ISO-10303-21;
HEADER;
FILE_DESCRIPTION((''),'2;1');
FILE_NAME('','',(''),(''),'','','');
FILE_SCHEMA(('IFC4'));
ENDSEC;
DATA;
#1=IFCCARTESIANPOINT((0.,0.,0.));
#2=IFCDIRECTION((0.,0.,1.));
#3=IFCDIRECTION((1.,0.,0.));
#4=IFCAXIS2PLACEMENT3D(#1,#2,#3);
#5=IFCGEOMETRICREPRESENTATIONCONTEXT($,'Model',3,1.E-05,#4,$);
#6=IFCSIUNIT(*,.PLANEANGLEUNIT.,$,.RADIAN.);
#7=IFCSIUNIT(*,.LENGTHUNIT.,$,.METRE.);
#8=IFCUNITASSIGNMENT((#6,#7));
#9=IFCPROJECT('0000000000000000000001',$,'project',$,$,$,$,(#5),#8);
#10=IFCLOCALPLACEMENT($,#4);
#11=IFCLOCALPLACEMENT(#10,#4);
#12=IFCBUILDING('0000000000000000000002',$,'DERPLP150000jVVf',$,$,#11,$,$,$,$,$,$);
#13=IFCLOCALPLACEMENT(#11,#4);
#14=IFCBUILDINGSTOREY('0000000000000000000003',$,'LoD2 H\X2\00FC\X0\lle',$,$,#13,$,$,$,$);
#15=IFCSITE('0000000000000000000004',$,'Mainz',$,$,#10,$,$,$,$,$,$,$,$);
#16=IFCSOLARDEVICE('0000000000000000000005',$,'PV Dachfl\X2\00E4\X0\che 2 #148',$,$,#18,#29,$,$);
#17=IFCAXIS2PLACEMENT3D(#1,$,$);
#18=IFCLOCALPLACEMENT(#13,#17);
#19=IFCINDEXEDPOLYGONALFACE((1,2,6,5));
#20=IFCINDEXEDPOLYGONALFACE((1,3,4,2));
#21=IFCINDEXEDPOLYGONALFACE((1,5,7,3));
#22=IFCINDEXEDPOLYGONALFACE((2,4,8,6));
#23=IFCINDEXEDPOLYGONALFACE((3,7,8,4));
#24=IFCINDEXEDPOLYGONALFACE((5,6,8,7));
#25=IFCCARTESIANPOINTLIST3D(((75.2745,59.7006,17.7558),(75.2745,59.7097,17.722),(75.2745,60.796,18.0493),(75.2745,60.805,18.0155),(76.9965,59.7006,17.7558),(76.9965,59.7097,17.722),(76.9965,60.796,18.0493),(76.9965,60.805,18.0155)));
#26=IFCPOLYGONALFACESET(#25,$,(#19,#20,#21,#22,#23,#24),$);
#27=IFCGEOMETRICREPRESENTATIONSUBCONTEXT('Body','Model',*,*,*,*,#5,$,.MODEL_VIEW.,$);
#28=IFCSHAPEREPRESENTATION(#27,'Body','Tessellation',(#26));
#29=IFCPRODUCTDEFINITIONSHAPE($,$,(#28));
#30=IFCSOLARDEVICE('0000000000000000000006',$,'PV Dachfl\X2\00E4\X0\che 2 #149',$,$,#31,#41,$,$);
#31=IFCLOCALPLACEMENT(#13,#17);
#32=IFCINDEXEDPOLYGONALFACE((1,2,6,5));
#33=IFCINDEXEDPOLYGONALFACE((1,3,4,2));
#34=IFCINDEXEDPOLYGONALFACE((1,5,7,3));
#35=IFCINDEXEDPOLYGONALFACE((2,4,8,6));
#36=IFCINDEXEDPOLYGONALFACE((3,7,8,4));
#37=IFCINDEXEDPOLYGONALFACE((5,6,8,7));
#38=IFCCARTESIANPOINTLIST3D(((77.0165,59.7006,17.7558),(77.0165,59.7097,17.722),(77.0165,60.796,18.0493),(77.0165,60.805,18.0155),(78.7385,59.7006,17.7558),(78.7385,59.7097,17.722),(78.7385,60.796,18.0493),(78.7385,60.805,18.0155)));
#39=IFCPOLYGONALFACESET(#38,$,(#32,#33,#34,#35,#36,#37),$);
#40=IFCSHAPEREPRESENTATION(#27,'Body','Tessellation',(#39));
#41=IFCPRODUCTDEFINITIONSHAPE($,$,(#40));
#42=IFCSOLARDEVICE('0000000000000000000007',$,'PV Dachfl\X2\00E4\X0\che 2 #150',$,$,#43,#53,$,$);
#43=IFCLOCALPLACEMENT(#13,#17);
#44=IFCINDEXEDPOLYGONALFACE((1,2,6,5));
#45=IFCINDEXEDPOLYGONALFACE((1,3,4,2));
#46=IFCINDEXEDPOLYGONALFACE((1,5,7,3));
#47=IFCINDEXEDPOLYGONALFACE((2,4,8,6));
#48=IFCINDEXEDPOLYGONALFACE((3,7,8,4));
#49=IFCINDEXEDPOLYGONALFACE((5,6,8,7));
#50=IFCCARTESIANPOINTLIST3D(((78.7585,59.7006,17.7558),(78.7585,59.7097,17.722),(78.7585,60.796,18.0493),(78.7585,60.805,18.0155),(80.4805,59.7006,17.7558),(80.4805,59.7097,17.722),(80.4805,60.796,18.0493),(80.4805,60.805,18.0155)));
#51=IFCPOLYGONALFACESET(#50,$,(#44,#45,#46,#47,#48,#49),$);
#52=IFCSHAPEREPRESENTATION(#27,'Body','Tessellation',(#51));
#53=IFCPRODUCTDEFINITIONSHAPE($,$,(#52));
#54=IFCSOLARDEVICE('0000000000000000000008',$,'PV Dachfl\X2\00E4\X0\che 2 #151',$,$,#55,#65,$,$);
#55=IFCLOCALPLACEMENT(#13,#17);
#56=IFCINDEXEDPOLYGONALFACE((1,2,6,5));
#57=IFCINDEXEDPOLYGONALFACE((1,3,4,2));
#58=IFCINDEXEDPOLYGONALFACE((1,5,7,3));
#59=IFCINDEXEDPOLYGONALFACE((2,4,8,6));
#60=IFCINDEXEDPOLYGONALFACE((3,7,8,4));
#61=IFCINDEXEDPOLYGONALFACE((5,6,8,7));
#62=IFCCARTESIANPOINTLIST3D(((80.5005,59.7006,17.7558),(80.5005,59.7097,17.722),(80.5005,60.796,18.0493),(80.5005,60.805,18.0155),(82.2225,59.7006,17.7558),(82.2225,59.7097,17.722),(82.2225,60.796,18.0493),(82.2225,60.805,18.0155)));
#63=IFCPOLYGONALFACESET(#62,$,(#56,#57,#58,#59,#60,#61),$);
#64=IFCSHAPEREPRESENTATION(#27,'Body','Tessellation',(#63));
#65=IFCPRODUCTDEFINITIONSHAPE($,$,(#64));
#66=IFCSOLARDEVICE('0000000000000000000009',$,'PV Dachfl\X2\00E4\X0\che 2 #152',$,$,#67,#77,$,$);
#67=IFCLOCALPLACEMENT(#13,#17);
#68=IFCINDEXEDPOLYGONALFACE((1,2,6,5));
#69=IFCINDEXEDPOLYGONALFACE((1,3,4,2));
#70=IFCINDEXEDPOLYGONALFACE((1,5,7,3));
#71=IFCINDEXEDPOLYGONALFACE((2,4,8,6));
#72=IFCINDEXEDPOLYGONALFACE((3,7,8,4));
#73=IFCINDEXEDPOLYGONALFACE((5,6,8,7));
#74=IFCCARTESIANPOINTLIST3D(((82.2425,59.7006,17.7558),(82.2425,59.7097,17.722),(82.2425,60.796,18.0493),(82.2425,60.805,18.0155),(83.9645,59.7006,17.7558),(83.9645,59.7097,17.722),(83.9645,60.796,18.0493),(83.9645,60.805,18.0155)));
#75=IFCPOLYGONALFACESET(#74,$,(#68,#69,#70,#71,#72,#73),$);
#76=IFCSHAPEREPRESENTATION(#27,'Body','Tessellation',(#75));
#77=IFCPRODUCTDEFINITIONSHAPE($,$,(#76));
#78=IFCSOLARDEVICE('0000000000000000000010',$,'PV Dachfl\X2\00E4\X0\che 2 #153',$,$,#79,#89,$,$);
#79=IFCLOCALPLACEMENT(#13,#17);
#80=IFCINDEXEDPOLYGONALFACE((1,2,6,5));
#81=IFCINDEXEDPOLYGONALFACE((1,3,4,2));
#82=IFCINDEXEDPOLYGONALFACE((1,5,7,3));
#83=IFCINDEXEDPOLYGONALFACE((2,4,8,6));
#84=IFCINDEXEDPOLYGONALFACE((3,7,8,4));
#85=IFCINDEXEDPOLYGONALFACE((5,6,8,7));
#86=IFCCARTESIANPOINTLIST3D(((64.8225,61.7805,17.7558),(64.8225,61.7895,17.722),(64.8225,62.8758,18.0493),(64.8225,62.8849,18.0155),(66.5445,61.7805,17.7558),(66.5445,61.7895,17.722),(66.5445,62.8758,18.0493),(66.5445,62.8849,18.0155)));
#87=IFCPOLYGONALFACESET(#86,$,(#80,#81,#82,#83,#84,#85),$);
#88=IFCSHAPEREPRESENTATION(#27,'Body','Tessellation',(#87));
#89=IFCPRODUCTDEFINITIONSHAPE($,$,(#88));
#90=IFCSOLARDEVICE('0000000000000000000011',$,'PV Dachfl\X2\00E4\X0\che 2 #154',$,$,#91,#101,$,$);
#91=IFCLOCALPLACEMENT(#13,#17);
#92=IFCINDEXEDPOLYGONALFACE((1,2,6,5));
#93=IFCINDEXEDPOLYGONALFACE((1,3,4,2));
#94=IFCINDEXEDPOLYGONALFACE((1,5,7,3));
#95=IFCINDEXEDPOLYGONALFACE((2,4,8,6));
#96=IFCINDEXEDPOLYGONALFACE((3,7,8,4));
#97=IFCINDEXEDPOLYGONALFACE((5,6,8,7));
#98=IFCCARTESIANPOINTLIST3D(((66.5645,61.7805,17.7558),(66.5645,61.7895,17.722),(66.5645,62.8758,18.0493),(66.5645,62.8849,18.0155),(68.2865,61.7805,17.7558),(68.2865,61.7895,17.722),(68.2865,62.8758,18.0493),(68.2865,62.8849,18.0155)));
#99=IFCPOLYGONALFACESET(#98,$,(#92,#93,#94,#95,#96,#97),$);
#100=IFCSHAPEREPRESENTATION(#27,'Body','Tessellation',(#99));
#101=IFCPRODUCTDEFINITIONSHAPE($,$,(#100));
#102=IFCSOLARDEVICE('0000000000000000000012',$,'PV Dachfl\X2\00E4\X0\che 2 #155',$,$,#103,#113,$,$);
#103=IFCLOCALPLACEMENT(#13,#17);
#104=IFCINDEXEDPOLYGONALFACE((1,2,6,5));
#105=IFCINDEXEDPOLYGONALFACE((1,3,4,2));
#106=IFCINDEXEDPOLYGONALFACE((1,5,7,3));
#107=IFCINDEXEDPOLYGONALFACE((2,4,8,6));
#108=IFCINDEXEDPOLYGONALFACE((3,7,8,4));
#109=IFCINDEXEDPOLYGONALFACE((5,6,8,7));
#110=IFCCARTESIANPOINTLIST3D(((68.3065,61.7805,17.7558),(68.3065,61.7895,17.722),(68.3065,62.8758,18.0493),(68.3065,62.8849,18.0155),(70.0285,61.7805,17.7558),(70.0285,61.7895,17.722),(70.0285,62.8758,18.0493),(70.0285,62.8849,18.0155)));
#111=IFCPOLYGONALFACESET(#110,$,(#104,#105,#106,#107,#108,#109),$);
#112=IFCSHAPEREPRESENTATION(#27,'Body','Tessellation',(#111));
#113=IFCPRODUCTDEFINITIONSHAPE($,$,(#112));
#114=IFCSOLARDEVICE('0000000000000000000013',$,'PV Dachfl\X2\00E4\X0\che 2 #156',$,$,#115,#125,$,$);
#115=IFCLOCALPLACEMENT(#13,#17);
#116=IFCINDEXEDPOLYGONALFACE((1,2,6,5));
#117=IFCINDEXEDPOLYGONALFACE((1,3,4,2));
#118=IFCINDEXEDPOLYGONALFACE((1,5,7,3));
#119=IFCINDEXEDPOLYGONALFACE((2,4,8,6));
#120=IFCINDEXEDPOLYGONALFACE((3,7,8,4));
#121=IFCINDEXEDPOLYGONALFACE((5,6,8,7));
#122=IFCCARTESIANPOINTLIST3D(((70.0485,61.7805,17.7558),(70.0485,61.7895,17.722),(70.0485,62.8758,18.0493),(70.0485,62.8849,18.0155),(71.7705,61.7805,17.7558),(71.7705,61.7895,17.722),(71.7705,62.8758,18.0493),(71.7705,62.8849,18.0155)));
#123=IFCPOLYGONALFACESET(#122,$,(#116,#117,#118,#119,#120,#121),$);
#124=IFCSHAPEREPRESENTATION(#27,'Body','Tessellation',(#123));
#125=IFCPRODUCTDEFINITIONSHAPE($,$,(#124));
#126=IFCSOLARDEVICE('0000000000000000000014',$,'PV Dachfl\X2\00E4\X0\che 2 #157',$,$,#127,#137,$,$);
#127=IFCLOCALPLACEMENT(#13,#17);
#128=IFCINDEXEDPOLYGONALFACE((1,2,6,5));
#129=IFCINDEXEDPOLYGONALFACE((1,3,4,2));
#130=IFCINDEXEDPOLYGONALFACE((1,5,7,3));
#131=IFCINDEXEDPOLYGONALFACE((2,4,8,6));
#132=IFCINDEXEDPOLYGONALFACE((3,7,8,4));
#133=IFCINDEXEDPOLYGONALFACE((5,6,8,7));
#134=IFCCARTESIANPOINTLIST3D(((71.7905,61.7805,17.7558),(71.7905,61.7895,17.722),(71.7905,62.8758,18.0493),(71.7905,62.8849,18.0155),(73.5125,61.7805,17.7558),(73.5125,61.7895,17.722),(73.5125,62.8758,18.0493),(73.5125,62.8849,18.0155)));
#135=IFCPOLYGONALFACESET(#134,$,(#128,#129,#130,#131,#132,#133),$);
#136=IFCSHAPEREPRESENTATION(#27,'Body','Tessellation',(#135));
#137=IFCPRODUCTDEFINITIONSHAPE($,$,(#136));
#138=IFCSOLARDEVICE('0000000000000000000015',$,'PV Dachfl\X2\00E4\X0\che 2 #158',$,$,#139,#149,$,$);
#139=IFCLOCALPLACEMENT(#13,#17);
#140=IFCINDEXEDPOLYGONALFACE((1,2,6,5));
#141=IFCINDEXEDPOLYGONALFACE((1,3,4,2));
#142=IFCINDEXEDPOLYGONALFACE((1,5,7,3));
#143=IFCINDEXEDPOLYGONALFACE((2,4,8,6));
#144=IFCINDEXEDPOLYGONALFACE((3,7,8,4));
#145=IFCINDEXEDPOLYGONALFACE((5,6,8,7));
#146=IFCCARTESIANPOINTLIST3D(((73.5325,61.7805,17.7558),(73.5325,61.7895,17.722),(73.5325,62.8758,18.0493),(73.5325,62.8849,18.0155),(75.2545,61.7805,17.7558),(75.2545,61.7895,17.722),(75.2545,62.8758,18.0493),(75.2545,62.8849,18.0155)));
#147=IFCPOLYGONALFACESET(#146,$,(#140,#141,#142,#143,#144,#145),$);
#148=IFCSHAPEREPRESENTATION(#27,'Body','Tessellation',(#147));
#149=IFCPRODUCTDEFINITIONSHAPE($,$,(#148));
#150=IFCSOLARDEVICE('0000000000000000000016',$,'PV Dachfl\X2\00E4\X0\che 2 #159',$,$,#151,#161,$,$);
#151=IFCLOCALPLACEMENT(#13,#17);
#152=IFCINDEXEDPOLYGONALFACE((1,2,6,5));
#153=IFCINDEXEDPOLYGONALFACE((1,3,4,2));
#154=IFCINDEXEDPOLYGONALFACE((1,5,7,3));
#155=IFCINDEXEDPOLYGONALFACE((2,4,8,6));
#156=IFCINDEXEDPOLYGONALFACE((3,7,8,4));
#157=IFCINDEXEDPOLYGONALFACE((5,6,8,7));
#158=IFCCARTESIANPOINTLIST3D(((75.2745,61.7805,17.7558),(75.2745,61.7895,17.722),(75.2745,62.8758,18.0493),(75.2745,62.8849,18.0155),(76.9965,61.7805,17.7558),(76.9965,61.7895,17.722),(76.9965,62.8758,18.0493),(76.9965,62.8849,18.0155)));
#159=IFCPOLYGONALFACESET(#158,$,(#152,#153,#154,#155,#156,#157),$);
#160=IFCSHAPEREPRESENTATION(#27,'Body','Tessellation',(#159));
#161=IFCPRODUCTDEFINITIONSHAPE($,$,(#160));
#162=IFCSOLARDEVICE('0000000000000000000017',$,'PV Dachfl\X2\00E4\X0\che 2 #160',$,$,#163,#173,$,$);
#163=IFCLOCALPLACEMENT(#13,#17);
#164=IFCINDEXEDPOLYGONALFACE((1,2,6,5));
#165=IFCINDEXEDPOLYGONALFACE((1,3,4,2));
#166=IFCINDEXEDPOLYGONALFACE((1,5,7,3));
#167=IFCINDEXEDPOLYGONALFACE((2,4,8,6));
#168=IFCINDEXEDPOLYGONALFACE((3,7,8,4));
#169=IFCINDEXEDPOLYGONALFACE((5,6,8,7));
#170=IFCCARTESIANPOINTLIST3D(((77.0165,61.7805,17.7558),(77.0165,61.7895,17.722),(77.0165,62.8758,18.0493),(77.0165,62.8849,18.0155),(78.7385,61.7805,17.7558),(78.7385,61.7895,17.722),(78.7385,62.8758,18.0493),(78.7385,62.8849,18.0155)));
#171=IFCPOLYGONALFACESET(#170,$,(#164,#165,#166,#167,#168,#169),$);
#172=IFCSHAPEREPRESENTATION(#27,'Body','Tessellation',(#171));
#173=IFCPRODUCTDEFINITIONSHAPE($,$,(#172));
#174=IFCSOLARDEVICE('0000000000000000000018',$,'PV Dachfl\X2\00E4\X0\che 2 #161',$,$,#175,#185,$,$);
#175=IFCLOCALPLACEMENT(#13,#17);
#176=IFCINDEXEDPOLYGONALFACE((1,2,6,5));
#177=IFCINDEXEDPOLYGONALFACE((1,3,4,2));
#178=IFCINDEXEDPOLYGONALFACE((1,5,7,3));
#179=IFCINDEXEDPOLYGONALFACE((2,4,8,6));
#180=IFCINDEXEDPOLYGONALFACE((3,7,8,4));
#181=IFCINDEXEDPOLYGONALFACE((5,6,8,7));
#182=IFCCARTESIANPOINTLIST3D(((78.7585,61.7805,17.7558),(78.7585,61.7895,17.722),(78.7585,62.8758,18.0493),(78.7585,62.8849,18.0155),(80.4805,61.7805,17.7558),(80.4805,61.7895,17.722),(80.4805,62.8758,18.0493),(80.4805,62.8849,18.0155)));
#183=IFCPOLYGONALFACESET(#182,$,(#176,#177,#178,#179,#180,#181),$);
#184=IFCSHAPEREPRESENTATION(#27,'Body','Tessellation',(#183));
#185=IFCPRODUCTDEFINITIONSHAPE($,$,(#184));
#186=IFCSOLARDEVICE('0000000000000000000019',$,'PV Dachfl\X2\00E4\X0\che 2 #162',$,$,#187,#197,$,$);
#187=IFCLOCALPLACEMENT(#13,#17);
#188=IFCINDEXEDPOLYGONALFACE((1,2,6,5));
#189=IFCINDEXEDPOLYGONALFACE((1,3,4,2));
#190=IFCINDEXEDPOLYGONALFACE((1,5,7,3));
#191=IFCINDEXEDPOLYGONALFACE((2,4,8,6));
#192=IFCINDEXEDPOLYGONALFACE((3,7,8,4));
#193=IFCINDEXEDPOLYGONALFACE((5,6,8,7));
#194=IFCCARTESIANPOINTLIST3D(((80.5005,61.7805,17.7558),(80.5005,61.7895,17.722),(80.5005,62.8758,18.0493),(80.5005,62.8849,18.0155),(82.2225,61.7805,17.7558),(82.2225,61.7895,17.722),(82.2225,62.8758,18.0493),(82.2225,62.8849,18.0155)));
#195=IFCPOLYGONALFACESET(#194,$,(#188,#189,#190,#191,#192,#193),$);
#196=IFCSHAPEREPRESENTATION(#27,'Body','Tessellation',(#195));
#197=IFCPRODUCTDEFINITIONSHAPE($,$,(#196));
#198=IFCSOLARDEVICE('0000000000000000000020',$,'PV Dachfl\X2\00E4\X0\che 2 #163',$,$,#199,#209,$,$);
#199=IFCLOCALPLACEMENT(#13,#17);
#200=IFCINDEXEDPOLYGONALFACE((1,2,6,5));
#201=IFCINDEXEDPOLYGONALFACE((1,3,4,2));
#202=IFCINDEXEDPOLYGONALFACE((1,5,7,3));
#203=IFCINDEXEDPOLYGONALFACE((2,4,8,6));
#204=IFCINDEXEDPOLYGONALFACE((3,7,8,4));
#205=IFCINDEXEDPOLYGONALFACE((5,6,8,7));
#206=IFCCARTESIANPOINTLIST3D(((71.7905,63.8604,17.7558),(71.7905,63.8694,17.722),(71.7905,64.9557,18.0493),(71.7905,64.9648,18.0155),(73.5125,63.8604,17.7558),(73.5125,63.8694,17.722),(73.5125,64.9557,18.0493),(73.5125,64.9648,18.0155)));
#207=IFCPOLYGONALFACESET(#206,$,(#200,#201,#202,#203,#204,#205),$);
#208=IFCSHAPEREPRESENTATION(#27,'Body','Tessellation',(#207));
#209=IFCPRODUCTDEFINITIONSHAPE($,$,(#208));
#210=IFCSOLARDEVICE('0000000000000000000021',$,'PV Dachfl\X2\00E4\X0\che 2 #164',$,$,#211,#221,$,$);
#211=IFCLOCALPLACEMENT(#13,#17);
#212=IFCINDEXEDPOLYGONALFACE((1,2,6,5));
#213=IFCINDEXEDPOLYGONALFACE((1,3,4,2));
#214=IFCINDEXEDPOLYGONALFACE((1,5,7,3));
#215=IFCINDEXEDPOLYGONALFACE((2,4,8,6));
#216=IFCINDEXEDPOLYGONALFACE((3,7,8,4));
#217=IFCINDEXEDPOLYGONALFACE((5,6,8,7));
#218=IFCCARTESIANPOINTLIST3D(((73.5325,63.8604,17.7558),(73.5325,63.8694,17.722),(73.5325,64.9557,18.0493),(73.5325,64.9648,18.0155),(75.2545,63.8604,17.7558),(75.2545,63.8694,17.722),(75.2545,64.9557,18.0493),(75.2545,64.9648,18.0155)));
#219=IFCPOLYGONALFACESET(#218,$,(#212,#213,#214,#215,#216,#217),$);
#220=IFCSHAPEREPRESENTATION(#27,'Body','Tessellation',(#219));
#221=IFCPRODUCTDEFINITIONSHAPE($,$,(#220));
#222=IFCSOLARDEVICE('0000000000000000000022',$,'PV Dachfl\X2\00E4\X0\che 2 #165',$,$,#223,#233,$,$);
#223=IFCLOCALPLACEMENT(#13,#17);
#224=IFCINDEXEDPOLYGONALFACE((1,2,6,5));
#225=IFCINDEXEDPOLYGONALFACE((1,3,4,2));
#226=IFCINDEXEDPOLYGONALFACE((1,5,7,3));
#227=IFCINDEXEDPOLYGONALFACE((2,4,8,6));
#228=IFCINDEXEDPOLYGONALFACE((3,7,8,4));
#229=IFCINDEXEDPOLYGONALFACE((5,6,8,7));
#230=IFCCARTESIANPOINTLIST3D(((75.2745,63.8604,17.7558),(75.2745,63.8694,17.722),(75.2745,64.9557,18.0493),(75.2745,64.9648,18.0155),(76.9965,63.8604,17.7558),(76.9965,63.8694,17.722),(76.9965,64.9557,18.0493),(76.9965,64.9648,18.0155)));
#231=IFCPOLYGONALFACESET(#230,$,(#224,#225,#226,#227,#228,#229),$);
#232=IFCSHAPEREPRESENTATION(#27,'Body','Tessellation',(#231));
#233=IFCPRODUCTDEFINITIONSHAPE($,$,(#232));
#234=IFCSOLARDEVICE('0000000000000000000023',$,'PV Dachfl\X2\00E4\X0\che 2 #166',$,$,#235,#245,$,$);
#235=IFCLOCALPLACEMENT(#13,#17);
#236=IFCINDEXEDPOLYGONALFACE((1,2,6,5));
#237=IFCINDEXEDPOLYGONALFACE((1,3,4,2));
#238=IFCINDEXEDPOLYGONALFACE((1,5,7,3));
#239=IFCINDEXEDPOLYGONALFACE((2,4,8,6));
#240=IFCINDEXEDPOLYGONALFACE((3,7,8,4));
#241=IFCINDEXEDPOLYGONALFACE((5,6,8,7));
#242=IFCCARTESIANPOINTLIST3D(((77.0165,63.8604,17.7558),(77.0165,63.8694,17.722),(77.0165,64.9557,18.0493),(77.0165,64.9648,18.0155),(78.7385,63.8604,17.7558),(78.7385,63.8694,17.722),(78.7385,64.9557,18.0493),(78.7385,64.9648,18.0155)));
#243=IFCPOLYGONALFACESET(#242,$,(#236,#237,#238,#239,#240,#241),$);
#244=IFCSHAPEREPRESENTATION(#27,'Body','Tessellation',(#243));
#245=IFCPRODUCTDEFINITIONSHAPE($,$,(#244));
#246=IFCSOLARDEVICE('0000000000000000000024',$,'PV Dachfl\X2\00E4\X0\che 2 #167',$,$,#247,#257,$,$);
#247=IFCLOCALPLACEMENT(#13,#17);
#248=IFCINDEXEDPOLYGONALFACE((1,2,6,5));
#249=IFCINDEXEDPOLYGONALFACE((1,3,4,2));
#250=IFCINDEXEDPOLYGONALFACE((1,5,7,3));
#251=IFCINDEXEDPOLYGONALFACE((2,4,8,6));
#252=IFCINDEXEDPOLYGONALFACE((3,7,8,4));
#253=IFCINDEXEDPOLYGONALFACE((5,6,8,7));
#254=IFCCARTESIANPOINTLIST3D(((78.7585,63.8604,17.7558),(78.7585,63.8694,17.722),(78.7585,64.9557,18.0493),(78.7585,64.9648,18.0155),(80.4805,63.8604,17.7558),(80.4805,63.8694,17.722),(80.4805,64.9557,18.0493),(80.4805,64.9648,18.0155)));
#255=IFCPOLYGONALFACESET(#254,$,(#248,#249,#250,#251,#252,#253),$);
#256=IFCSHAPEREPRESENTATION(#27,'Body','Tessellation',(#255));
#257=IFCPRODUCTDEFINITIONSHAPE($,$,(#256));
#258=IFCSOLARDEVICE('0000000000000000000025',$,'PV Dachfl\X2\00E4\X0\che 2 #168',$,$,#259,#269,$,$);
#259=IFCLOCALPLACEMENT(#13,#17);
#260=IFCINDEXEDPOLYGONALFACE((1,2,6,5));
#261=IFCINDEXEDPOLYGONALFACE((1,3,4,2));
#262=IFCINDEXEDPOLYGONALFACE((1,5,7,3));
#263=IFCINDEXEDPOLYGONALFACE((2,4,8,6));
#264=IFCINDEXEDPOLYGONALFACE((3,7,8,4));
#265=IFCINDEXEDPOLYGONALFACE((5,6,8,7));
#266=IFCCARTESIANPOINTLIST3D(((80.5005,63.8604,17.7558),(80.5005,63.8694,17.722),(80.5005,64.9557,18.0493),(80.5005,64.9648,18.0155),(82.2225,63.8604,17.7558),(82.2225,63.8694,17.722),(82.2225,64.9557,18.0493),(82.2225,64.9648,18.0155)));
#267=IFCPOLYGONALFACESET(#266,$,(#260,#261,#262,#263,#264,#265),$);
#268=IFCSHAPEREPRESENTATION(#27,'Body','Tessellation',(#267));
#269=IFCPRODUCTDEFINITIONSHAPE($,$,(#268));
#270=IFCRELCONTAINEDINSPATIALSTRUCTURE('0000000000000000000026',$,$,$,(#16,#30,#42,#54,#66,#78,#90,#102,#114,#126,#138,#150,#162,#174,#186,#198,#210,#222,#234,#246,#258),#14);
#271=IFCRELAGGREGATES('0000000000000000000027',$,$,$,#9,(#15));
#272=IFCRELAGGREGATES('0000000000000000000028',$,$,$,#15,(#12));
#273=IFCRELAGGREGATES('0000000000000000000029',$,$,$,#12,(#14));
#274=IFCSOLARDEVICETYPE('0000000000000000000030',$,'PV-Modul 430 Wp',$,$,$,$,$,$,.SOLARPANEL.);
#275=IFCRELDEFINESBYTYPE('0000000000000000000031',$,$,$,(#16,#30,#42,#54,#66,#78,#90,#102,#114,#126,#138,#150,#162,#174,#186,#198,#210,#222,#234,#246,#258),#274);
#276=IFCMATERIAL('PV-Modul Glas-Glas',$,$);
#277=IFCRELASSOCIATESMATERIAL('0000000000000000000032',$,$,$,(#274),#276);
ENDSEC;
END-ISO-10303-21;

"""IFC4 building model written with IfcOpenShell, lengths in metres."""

from ifc_helpers import new_model, si_unit, frame, frame_2d, origin, origin_with_axes, place, context, subcontext, project, spatial, rectangle, extrude, source, transform, mapped, material, type_object, type_shapes, element, save


model = new_model("IFC4")

# Units and contexts
model_context = context("Model", 3, precision=1e-05, world=origin_with_axes())
body_context = subcontext(model_context, "Body", "Model", "MODEL_VIEW")
ifc_project = project(units=[si_unit("PLANEANGLEUNIT", "RADIAN"), si_unit("LENGTHUNIT", "METRE")], contexts=[model_context])

# Site, building, storey
site_placement = place(None, origin_with_axes())
site = spatial("IfcSite", under=ifc_project, at=site_placement, Name="Mainz")
building_placement = place(site_placement, origin_with_axes())
building = spatial("IfcBuilding", under=site, at=building_placement, Name="DERPLP150000jVVf")
storey_placement = place(building_placement, origin_with_axes())
storey = spatial("IfcBuildingStorey", under=building, at=storey_placement, Name="LoD2 Hülle")

# Solar devices
ifc_material = material(Name="PV-Modul Glas-Glas")
solar_device_type = type_object("IfcSolarDeviceType", Name="PV-Modul 430 Wp", PredefinedType="SOLARPANEL", material=ifc_material)
shared_shape = source(origin_with_axes(), body_context, "Body", "SweptSolid", [
    extrude(rectangle(XDim=1.722, YDim=1.134, at=frame_2d((0.861, 0.567))), origin(), (0.0, 0.0, 1.0), 0.035),
])
type_shapes(solar_device_type, [shared_shape])
for number, where, z_axis, x_axis, name in (
    (1, (75.2745, 59.7097, 17.722), (0.0, -0.258819, 0.965926), (1.0, 0.0, 0.0), "PV Dachfläche 2 #148"),
    (2, (77.0165, 59.7097, 17.722), (0.0, -0.258819, 0.965926), (1.0, 0.0, 0.0), "PV Dachfläche 2 #149"),
    (3, (78.7585, 59.7097, 17.722), (0.0, -0.258819, 0.965926), (1.0, 0.0, 0.0), "PV Dachfläche 2 #150"),
    (4, (80.5005, 59.7097, 17.722), (0.0, -0.258819, 0.965926), (1.0, 0.0, 0.0), "PV Dachfläche 2 #151"),
    (5, (82.2425, 59.7097, 17.722), (0.0, -0.258819, 0.965926), (1.0, 0.0, 0.0), "PV Dachfläche 2 #152"),
    (6, (64.8225, 61.7895, 17.722), (0.0, -0.258819, 0.965926), (1.0, 0.0, 0.0), "PV Dachfläche 2 #153"),
    (7, (66.5645, 61.7895, 17.722), (0.0, -0.258819, 0.965926), (1.0, 0.0, 0.0), "PV Dachfläche 2 #154"),
    (8, (68.3065, 61.7895, 17.722), (0.0, -0.258819, 0.965926), (1.0, 0.0, 0.0), "PV Dachfläche 2 #155"),
    (9, (70.0485, 61.7895, 17.722), (0.0, -0.258819, 0.965926), (1.0, 0.0, 0.0), "PV Dachfläche 2 #156"),
    (10, (71.7905, 61.7895, 17.722), (0.0, -0.258819, 0.965926), (1.0, 0.0, 0.0), "PV Dachfläche 2 #157"),
    (11, (73.5325, 61.7895, 17.722), (0.0, -0.258819, 0.965926), (1.0, 0.0, 0.0), "PV Dachfläche 2 #158"),
    (12, (75.2745, 61.7895, 17.722), (0.0, -0.258819, 0.965926), (1.0, 0.0, 0.0), "PV Dachfläche 2 #159"),
    (13, (77.0165, 61.7895, 17.722), (0.0, -0.258819, 0.965926), (1.0, 0.0, 0.0), "PV Dachfläche 2 #160"),
    (14, (78.7585, 61.7895, 17.722), (0.0, -0.258819, 0.965926), (1.0, 0.0, 0.0), "PV Dachfläche 2 #161"),
    (15, (80.5005, 61.7895, 17.722), (0.0, -0.258819, 0.965926), (1.0, 0.0, 0.0), "PV Dachfläche 2 #162"),
    (16, (71.7905, 63.8694, 17.722), (0.0, -0.258819, 0.965926), (1.0, 0.0, 0.0), "PV Dachfläche 2 #163"),
    (17, (73.5325, 63.8694, 17.722), (0.0, -0.258819, 0.965926), (1.0, 0.0, 0.0), "PV Dachfläche 2 #164"),
    (18, (75.2745, 63.8694, 17.722), (0.0, -0.258819, 0.965926), (1.0, 0.0, 0.0), "PV Dachfläche 2 #165"),
    (19, (77.0165, 63.8694, 17.722), (0.0, -0.258819, 0.965926), (1.0, 0.0, 0.0), "PV Dachfläche 2 #166"),
    (20, (78.7585, 63.8694, 17.722), (0.0, -0.258819, 0.965926), (1.0, 0.0, 0.0), "PV Dachfläche 2 #167"),
    (21, (80.5005, 63.8694, 17.722), (0.0, -0.258819, 0.965926), (1.0, 0.0, 0.0), "PV Dachfläche 2 #168"),
):
    element("IfcSolarDevice", number, at=place(storey_placement, frame(where, z_axis=z_axis, x_axis=x_axis)), inside=storey, type_object=solar_device_type, Name=name, context=body_context, shape_type="MappedRepresentation", body=[
        mapped(shared_shape, transform((0.0, 0.0, 0.0), x_axis=(1.0, 0.0, 0.0), y_axis=(0.0, 1.0, 0.0), z_axis=(0.0, 0.0, 1.0), scale=1.0)),
    ])

save(model, "model.ifc")
